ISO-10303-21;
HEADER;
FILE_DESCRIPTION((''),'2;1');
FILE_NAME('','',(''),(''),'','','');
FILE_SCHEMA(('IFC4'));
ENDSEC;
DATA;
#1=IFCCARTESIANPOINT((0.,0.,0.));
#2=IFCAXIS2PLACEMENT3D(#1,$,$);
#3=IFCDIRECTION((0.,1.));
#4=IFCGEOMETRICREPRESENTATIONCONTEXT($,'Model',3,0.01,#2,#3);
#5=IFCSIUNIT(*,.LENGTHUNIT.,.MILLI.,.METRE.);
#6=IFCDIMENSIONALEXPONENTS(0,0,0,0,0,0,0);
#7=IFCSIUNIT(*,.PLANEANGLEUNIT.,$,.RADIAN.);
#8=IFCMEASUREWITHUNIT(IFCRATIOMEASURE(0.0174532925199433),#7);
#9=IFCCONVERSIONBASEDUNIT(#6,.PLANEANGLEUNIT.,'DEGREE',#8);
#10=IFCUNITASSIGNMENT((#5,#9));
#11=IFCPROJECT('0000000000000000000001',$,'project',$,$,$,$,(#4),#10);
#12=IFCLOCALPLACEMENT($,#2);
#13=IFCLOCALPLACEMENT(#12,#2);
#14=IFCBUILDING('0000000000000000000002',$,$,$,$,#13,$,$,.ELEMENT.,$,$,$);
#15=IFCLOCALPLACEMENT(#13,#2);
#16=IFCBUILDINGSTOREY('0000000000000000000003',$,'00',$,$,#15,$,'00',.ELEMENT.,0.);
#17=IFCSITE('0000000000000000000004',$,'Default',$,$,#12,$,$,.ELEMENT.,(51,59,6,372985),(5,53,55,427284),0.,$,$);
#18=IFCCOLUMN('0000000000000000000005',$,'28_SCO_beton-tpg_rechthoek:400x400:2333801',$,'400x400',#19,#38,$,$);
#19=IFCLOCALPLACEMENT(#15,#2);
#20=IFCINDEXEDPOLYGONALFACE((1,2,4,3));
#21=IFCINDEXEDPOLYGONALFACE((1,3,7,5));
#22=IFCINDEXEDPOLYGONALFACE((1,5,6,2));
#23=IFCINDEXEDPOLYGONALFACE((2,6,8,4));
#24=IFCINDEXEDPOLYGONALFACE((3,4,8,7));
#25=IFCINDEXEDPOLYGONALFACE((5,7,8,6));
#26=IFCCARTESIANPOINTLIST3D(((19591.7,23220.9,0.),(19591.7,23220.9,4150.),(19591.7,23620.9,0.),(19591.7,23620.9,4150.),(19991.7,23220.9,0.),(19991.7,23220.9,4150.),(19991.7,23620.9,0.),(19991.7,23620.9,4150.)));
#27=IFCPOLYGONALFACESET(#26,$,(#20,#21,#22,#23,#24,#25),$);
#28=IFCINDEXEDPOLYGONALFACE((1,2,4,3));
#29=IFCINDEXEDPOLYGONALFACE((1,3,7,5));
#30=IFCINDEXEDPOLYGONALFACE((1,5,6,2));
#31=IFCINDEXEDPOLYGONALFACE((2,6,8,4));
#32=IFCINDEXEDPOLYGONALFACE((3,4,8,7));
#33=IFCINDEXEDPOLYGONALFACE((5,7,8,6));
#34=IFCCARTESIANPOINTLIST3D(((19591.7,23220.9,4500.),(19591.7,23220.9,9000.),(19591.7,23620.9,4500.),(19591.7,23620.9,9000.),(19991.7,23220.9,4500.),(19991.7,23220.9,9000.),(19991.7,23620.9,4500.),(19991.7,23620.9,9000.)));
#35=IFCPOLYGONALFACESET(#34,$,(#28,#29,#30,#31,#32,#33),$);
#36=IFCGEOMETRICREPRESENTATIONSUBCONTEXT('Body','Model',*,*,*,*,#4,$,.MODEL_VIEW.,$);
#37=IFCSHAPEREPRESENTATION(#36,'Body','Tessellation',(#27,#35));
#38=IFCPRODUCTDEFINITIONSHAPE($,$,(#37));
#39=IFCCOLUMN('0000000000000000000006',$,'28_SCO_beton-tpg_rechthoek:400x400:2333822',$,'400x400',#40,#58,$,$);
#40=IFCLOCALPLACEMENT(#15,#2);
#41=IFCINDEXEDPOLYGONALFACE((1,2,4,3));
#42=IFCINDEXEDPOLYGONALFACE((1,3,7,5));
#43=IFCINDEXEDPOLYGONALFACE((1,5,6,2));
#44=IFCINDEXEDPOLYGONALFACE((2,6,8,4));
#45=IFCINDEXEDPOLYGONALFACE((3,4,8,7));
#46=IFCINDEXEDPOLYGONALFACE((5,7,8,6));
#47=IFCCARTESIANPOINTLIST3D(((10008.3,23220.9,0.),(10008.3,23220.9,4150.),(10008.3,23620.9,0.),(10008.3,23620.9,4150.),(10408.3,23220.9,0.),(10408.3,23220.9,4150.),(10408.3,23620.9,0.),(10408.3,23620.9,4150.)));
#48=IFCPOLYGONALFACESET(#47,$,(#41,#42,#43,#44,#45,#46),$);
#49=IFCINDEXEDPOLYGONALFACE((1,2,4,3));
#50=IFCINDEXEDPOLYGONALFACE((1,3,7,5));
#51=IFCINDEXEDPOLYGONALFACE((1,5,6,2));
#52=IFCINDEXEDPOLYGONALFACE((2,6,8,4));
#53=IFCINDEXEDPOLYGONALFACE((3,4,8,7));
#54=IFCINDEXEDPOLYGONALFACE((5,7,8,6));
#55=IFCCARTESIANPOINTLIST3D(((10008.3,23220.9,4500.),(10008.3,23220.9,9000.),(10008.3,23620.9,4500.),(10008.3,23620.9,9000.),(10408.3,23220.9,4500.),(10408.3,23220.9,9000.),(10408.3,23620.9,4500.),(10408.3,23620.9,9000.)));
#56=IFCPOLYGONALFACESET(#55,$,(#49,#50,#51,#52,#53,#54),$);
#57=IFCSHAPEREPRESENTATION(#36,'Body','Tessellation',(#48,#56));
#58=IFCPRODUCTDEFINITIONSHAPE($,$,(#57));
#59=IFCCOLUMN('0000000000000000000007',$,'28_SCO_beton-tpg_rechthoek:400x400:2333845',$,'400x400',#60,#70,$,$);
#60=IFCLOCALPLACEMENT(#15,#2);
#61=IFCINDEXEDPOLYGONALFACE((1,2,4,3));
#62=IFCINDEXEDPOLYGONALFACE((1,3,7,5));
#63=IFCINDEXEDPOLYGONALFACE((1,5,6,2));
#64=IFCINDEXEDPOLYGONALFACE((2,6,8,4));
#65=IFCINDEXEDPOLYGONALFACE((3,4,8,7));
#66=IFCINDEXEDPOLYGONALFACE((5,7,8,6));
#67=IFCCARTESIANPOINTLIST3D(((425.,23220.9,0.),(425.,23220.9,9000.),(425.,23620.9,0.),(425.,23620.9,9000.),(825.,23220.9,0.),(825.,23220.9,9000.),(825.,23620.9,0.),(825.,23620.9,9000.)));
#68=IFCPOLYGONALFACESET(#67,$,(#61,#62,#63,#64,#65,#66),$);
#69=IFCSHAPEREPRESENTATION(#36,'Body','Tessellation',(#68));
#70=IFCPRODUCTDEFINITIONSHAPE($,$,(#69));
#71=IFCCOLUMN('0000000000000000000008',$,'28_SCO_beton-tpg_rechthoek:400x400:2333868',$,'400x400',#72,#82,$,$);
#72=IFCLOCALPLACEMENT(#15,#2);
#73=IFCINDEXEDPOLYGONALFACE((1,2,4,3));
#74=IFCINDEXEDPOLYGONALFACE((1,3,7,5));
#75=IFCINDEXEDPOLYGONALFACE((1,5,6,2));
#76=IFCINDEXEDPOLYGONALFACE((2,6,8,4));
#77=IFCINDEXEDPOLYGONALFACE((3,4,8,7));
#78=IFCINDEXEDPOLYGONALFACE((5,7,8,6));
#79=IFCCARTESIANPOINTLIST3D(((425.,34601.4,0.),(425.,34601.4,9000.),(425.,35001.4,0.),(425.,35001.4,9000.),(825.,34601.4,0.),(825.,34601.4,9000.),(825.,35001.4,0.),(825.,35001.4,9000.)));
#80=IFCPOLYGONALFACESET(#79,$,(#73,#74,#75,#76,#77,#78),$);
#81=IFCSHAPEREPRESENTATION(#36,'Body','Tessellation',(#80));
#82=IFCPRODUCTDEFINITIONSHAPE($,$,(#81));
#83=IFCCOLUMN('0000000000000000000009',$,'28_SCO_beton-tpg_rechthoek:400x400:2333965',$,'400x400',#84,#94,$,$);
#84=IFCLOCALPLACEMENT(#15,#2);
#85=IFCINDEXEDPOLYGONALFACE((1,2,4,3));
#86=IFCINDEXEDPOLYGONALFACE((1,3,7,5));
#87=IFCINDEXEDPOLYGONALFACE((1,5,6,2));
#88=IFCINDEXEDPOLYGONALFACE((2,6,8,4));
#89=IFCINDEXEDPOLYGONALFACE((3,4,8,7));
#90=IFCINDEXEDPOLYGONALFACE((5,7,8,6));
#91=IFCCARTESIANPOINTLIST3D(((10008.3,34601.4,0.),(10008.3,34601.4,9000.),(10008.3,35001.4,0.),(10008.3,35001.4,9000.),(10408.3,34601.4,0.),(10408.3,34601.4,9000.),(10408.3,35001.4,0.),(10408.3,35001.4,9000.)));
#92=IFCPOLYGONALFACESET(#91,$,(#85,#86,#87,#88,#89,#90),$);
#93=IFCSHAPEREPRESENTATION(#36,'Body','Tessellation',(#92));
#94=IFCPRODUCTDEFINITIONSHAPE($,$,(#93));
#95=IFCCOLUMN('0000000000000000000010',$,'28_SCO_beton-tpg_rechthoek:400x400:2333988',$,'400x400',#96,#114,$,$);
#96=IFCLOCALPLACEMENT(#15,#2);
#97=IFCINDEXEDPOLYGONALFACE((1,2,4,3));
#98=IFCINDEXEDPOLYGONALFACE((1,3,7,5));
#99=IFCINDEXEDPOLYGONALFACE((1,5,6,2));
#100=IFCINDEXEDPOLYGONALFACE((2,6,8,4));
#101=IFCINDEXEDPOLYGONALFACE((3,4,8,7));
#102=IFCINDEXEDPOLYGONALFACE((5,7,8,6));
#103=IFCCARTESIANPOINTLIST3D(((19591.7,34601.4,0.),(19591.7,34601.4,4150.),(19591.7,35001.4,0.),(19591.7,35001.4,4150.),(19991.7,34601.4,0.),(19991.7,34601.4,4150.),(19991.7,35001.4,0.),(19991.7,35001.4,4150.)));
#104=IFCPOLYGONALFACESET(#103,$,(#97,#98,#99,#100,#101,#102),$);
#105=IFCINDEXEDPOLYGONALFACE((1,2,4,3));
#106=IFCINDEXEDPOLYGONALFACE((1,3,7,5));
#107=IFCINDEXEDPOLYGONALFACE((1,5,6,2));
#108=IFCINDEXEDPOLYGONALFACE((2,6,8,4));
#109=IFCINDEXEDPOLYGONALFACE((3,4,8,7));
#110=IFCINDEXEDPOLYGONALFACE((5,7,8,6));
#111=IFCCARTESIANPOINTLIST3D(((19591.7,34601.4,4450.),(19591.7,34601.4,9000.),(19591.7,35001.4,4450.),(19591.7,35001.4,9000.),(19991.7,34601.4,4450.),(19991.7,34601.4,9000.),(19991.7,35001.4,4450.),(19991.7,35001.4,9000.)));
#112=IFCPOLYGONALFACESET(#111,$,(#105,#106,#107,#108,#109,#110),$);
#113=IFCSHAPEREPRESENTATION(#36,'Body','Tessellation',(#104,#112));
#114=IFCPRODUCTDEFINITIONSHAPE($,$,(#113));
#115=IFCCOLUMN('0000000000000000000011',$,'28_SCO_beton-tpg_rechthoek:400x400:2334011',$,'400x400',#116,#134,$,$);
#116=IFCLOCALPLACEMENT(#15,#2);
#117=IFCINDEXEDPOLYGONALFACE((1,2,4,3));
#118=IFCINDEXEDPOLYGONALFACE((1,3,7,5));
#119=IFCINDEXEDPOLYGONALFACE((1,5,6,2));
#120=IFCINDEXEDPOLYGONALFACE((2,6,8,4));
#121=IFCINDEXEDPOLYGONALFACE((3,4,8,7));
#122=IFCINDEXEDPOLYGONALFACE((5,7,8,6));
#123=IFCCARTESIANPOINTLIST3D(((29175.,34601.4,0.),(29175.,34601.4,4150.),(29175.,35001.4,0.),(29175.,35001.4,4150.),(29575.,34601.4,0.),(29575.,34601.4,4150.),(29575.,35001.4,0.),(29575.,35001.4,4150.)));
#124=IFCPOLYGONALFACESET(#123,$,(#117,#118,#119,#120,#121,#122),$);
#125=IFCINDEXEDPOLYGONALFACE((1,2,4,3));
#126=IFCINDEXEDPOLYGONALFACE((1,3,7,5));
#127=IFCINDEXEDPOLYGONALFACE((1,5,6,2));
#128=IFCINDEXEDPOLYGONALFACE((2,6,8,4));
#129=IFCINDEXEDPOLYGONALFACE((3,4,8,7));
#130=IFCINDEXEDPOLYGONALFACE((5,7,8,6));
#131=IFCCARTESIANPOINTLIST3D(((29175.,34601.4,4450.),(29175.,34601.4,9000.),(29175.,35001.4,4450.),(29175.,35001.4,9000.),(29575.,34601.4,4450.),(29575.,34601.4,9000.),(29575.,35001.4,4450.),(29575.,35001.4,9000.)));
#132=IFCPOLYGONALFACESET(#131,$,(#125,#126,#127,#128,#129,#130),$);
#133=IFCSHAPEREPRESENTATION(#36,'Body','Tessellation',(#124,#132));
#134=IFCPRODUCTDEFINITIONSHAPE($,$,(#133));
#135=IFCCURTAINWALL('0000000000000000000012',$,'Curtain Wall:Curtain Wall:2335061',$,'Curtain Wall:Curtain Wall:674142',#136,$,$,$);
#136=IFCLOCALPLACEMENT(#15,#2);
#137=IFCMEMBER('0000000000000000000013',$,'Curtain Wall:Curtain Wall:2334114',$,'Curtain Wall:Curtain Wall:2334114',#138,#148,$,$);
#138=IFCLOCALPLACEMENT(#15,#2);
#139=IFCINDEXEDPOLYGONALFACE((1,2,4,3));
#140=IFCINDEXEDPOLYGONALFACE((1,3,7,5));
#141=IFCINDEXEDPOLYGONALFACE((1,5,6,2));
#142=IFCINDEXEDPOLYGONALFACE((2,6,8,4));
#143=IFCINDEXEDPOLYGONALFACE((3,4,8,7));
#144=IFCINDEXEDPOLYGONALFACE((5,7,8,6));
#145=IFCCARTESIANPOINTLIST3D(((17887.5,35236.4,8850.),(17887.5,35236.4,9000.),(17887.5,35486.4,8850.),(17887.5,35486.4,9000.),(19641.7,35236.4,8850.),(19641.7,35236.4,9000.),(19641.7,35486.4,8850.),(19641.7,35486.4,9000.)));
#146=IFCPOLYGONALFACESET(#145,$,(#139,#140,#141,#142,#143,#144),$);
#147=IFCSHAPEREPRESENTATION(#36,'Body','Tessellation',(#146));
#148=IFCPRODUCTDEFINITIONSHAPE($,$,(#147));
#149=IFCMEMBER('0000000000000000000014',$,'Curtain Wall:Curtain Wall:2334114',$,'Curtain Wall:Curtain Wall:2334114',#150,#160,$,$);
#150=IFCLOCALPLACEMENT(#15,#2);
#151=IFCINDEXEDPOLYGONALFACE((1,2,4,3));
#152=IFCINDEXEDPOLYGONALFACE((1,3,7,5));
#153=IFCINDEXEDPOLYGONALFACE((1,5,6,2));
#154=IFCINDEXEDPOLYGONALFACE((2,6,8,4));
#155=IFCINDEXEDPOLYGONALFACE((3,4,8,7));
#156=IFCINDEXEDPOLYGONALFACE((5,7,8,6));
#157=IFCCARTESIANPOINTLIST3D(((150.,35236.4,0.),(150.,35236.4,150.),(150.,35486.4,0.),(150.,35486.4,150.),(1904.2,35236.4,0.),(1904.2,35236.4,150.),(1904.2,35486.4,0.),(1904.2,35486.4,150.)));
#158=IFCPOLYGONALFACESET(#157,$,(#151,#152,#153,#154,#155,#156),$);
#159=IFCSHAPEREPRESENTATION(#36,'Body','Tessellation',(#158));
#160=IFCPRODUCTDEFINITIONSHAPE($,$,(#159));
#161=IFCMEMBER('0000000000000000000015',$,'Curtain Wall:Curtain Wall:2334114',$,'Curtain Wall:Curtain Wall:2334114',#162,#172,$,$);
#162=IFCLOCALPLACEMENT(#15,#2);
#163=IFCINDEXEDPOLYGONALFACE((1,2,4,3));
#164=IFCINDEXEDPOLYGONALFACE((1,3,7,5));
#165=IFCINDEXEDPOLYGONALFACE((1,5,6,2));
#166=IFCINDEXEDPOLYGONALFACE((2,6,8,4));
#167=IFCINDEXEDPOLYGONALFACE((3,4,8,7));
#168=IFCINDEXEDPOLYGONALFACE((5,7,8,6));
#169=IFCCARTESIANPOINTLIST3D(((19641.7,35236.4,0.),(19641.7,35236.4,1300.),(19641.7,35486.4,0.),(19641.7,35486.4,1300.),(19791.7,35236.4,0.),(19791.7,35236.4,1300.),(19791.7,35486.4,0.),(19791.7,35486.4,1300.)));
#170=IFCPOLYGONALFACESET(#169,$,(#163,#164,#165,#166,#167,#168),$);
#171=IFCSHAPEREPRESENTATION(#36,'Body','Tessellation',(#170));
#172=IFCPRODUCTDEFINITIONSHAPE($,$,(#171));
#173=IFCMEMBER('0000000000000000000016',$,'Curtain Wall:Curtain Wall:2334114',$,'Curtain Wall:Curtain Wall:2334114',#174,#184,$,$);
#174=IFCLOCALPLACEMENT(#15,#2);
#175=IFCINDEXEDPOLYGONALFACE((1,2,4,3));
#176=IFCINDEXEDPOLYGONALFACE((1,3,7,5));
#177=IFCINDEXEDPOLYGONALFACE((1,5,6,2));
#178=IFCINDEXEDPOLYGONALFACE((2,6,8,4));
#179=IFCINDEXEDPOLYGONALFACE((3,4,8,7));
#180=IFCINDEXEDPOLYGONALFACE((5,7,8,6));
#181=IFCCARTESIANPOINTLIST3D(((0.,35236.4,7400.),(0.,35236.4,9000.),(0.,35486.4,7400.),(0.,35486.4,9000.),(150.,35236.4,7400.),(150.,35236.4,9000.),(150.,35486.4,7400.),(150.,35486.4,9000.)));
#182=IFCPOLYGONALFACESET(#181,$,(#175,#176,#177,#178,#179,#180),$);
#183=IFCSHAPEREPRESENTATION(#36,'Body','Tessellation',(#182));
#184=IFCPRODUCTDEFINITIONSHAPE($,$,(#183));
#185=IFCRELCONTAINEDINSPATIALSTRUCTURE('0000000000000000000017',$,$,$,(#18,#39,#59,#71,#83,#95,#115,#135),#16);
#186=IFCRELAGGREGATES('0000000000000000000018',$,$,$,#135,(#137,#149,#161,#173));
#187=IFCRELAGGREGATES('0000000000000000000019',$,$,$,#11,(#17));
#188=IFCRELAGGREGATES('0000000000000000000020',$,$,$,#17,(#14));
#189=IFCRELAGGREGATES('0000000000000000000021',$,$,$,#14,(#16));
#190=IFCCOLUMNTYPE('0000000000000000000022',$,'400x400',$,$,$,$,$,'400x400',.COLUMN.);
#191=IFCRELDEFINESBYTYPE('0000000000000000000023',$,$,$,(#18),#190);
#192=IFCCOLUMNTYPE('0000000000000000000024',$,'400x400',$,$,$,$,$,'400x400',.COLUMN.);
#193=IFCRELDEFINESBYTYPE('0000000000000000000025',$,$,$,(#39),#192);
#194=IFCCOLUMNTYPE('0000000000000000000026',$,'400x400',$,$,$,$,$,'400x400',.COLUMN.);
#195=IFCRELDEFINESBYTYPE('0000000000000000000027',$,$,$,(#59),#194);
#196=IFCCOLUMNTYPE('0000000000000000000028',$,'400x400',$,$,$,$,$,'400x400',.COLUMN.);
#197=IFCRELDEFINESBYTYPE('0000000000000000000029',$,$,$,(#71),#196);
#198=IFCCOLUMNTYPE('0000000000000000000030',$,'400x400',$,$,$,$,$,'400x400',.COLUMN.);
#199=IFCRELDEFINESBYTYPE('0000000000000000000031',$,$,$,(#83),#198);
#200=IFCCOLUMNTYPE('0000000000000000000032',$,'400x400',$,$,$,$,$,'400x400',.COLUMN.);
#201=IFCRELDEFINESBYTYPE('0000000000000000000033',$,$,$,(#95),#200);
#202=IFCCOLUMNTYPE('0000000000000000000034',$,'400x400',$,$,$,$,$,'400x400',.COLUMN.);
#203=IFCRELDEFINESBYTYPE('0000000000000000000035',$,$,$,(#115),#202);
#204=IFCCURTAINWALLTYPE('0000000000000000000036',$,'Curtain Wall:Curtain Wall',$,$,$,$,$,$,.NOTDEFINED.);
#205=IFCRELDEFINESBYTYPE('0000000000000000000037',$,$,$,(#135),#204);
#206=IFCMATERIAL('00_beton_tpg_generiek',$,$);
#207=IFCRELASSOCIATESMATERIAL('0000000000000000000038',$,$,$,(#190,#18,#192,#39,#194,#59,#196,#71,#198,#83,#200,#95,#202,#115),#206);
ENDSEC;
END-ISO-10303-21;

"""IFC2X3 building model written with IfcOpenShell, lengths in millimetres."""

from ifc_helpers import new_model, entity, si_unit, converted_unit, direction, frame, frame_2d, origin, origin_2d_with_axis, place, context, subcontext, project, spatial, rectangle, extrude, source, transform, mapped, material, type_object, type_shapes, element, aggregate, save


model = new_model("IFC2X3")

# Units and contexts
model_context = context("Model", 3, precision=0.01, world=origin(), true_north=direction((0.0, 1.0)))
body_context = subcontext(model_context, "Body", "Model", "MODEL_VIEW")
ifc_project = project(units=[si_unit("LENGTHUNIT", "METRE", prefix="MILLI"), converted_unit("PLANEANGLEUNIT", "DEGREE", entity("IfcRatioMeasure", 0.0174532925199433), si_unit("PLANEANGLEUNIT", "RADIAN"), dimensions=[0, 0, 0, 0, 0, 0, 0])], contexts=[model_context])

# Site, building, storey
site_placement = place(None, origin())
site = spatial("IfcSite", under=ifc_project, at=site_placement, Name="Default", CompositionType="ELEMENT", RefLatitude=(51, 59, 6, 372985), RefLongitude=(5, 53, 55, 427284), RefElevation=0.0)
building_placement = place(site_placement, origin())
building = spatial("IfcBuilding", under=site, at=building_placement, CompositionType="ELEMENT")
storey_placement = place(building_placement, origin())
storey = spatial("IfcBuildingStorey", under=building, at=storey_placement, Name="00", LongName="00", CompositionType="ELEMENT", Elevation=0.0)

# Columns
ifc_material_1 = material(Name="00_beton_tpg_generiek")
column_type_1 = type_object("IfcColumnType", Name="400x400", ElementType="400x400", PredefinedType="COLUMN", material=ifc_material_1)
shared_shape_1 = source(origin(), body_context, "Body", "SweptSolid", [
    extrude(rectangle(XDim=400.0, YDim=400.0, at=frame_2d((0.0, 0.0), x_axis=(1.0, 0.0))), frame((19791.7, 23420.9, 0.0), z_axis=(0.0, 0.0, 1.0), x_axis=(0.0, -1.0, 0.0)), (0.0, 0.0, 1.0), 4150.0),
    extrude(rectangle(XDim=400.0, YDim=400.0, at=frame_2d((0.0, 0.0), x_axis=(1.0, 0.0))), frame((19791.7, 23420.9, 4500.0), z_axis=(0.0, 0.0, 1.0), x_axis=(0.0, -1.0, 0.0)), (0.0, 0.0, 1.0), 4500.0),
])
type_shapes(column_type_1, [shared_shape_1])
column_1_placement = place(storey_placement, origin())
element("IfcColumn", 1, at=column_1_placement, inside=storey, type_object=column_type_1, material=ifc_material_1, Name="28_SCO_beton-tpg_rechthoek:400x400:2333801", ObjectType="400x400", context=body_context, shape_type="MappedRepresentation", body=[
    mapped(shared_shape_1, transform((0.0, 0.0, 0.0), scale=1.0)),
])
column_type_2 = type_object("IfcColumnType", Name="400x400", ElementType="400x400", PredefinedType="COLUMN", material=ifc_material_1)
shared_shape_2 = source(origin(), body_context, "Body", "SweptSolid", [
    extrude(rectangle(XDim=400.0, YDim=400.0, at=frame_2d((0.0, 0.0), x_axis=(1.0, 0.0))), frame((10208.3, 23420.9, 0.0), z_axis=(0.0, 0.0, 1.0), x_axis=(0.0, -1.0, 0.0)), (0.0, 0.0, 1.0), 4150.0),
    extrude(rectangle(XDim=400.0, YDim=400.0, at=frame_2d((0.0, 0.0), x_axis=(1.0, 0.0))), frame((10208.3, 23420.9, 4500.0), z_axis=(0.0, 0.0, 1.0), x_axis=(0.0, -1.0, 0.0)), (0.0, 0.0, 1.0), 4500.0),
])
type_shapes(column_type_2, [shared_shape_2])
column_2_placement = place(storey_placement, origin())
element("IfcColumn", 2, at=column_2_placement, inside=storey, type_object=column_type_2, material=ifc_material_1, Name="28_SCO_beton-tpg_rechthoek:400x400:2333822", ObjectType="400x400", context=body_context, shape_type="MappedRepresentation", body=[
    mapped(shared_shape_2, transform((0.0, 0.0, 0.0), scale=1.0)),
])
column_type_3 = type_object("IfcColumnType", Name="400x400", ElementType="400x400", PredefinedType="COLUMN", material=ifc_material_1)
shared_shape_3 = source(origin(), body_context, "Body", "SweptSolid", [
    extrude(rectangle(XDim=400.0, YDim=400.0, at=frame_2d((0.0, 0.0), x_axis=(1.0, 0.0))), frame((625.0, 23420.9, 0.0), z_axis=(0.0, 0.0, 1.0), x_axis=(0.0, -1.0, 0.0)), (0.0, 0.0, 1.0), 9000.0),
])
type_shapes(column_type_3, [shared_shape_3])
column_3_placement = place(storey_placement, origin())
element("IfcColumn", 3, at=column_3_placement, inside=storey, type_object=column_type_3, material=ifc_material_1, Name="28_SCO_beton-tpg_rechthoek:400x400:2333845", ObjectType="400x400", context=body_context, shape_type="MappedRepresentation", body=[
    mapped(shared_shape_3, transform((0.0, 0.0, 0.0), scale=1.0)),
])
column_type_4 = type_object("IfcColumnType", Name="400x400", ElementType="400x400", PredefinedType="COLUMN", material=ifc_material_1)
shared_shape_4 = source(origin(), body_context, "Body", "SweptSolid", [
    extrude(rectangle(XDim=400.0, YDim=400.0, at=frame_2d((0.0, 0.0), x_axis=(1.0, 0.0))), frame((625.0, 34801.4, 0.0), z_axis=(0.0, 0.0, 1.0), x_axis=(0.0, -1.0, 0.0)), (0.0, 0.0, 1.0), 9000.0),
])
type_shapes(column_type_4, [shared_shape_4])
column_4_placement = place(storey_placement, origin())
element("IfcColumn", 4, at=column_4_placement, inside=storey, type_object=column_type_4, material=ifc_material_1, Name="28_SCO_beton-tpg_rechthoek:400x400:2333868", ObjectType="400x400", context=body_context, shape_type="MappedRepresentation", body=[
    mapped(shared_shape_4, transform((0.0, 0.0, 0.0), scale=1.0)),
])
column_type_5 = type_object("IfcColumnType", Name="400x400", ElementType="400x400", PredefinedType="COLUMN", material=ifc_material_1)
shared_shape_5 = source(origin(), body_context, "Body", "SweptSolid", [
    extrude(rectangle(XDim=400.0, YDim=400.0, at=origin_2d_with_axis()), frame((10208.3, 34801.4, 0.0), z_axis=(0.0, 0.0, 1.0), x_axis=(0.0, -1.0, 0.0)), (0.0, 0.0, 1.0), 9000.0),
])
type_shapes(column_type_5, [shared_shape_5])
column_5_placement = place(storey_placement, origin())
element("IfcColumn", 5, at=column_5_placement, inside=storey, type_object=column_type_5, material=ifc_material_1, Name="28_SCO_beton-tpg_rechthoek:400x400:2333965", ObjectType="400x400", context=body_context, shape_type="MappedRepresentation", body=[
    mapped(shared_shape_5, transform((0.0, 0.0, 0.0), scale=1.0)),
])
column_type_6 = type_object("IfcColumnType", Name="400x400", ElementType="400x400", PredefinedType="COLUMN", material=ifc_material_1)
shared_shape_6 = source(origin(), body_context, "Body", "SweptSolid", [
    extrude(rectangle(XDim=400.0, YDim=400.0, at=frame_2d((0.0, 0.0), x_axis=(1.0, 0.0))), frame((19791.7, 34801.4, 0.0), z_axis=(0.0, 0.0, 1.0), x_axis=(0.0, -1.0, 0.0)), (0.0, 0.0, 1.0), 4150.0),
    extrude(rectangle(XDim=400.0, YDim=400.0, at=frame_2d((0.0, 0.0), x_axis=(1.0, 0.0))), frame((19791.7, 34801.4, 4450.0), z_axis=(0.0, 0.0, 1.0), x_axis=(0.0, -1.0, 0.0)), (0.0, 0.0, 1.0), 4550.0),
])
type_shapes(column_type_6, [shared_shape_6])
column_6_placement = place(storey_placement, origin())
element("IfcColumn", 6, at=column_6_placement, inside=storey, type_object=column_type_6, material=ifc_material_1, Name="28_SCO_beton-tpg_rechthoek:400x400:2333988", ObjectType="400x400", context=body_context, shape_type="MappedRepresentation", body=[
    mapped(shared_shape_6, transform((0.0, 0.0, 0.0), scale=1.0)),
])
column_type_7 = type_object("IfcColumnType", Name="400x400", ElementType="400x400", PredefinedType="COLUMN", material=ifc_material_1)
shared_shape_7 = source(origin(), body_context, "Body", "SweptSolid", [
    extrude(rectangle(XDim=400.0, YDim=400.0, at=frame_2d((0.0, 0.0), x_axis=(1.0, 0.0))), frame((29375.0, 34801.4, 0.0), z_axis=(0.0, 0.0, 1.0), x_axis=(0.0, -1.0, 0.0)), (0.0, 0.0, 1.0), 4150.0),
    extrude(rectangle(XDim=400.0, YDim=400.0, at=frame_2d((0.0, 0.0), x_axis=(1.0, 0.0))), frame((29375.0, 34801.4, 4450.0), z_axis=(0.0, 0.0, 1.0), x_axis=(0.0, -1.0, 0.0)), (0.0, 0.0, 1.0), 4550.0),
])
type_shapes(column_type_7, [shared_shape_7])
column_7_placement = place(storey_placement, origin())
element("IfcColumn", 7, at=column_7_placement, inside=storey, type_object=column_type_7, material=ifc_material_1, Name="28_SCO_beton-tpg_rechthoek:400x400:2334011", ObjectType="400x400", context=body_context, shape_type="MappedRepresentation", body=[
    mapped(shared_shape_7, transform((0.0, 0.0, 0.0), scale=1.0)),
])

# Curtain wall, members
curtain_wall_type = type_object("IfcCurtainWallType", Name="Curtain Wall:Curtain Wall", PredefinedType="NOTDEFINED")
curtain_wall_1_placement = place(storey_placement, origin())
curtain_wall_1 = element("IfcCurtainWall", 8, at=curtain_wall_1_placement, inside=storey, type_object=curtain_wall_type, Name="Curtain Wall:Curtain Wall:2335061", ObjectType="Curtain Wall:Curtain Wall:674142")
member_1_placement = place(curtain_wall_1_placement, origin())
member_1 = element("IfcMember", 9, at=member_1_placement, Name="Curtain Wall:Curtain Wall:2334114", ObjectType="Curtain Wall:Curtain Wall:2334114", context=body_context, shape_type="SweptSolid", body=[
    extrude(rectangle(XDim=150.0, YDim=250.0, at=frame_2d((0.0, 0.0), x_axis=(1.0, 0.0))), frame((19641.7, 35361.4, 8925.0), z_axis=(-1.0, 0.0, 0.0), x_axis=(0.0, 0.0, -1.0)), (0.0, 0.0, 1.0), 1754.2),
])
member_2_placement = place(curtain_wall_1_placement, origin())
member_2 = element("IfcMember", 10, at=member_2_placement, Name="Curtain Wall:Curtain Wall:2334114", ObjectType="Curtain Wall:Curtain Wall:2334114", context=body_context, shape_type="SweptSolid", body=[
    extrude(rectangle(XDim=150.0, YDim=250.0, at=frame_2d((0.0, 0.0), x_axis=(1.0, 0.0))), frame((150.0, 35361.4, 75.0), z_axis=(1.0, 0.0, 0.0), x_axis=(0.0, 0.0, -1.0)), (0.0, 0.0, 1.0), 1754.2),
])
member_3_placement = place(curtain_wall_1_placement, origin())
member_3 = element("IfcMember", 11, at=member_3_placement, Name="Curtain Wall:Curtain Wall:2334114", ObjectType="Curtain Wall:Curtain Wall:2334114", context=body_context, shape_type="SweptSolid", body=[
    extrude(rectangle(XDim=150.0, YDim=250.0, at=frame_2d((0.0, 0.0), x_axis=(1.0, 0.0))), frame((19716.7, 35361.4, 0.0), z_axis=(0.0, 0.0, 1.0), x_axis=(-1.0, 0.0, 0.0)), (0.0, 0.0, 1.0), 1300.0),
])
member_4_placement = place(curtain_wall_1_placement, origin())
member_4 = element("IfcMember", 12, at=member_4_placement, Name="Curtain Wall:Curtain Wall:2334114", ObjectType="Curtain Wall:Curtain Wall:2334114", context=body_context, shape_type="SweptSolid", body=[
    extrude(rectangle(XDim=150.0, YDim=250.0, at=frame_2d((0.0, 0.0), x_axis=(1.0, 0.0))), frame((75.0, 35361.4, 9000.0), z_axis=(0.0, 0.0, -1.0), x_axis=(-1.0, 0.0, 0.0)), (0.0, 0.0, 1.0), 1600.0),
])
aggregate(curtain_wall_1, [member_1, member_2, member_3, member_4])

save(model, "model.ifc")
